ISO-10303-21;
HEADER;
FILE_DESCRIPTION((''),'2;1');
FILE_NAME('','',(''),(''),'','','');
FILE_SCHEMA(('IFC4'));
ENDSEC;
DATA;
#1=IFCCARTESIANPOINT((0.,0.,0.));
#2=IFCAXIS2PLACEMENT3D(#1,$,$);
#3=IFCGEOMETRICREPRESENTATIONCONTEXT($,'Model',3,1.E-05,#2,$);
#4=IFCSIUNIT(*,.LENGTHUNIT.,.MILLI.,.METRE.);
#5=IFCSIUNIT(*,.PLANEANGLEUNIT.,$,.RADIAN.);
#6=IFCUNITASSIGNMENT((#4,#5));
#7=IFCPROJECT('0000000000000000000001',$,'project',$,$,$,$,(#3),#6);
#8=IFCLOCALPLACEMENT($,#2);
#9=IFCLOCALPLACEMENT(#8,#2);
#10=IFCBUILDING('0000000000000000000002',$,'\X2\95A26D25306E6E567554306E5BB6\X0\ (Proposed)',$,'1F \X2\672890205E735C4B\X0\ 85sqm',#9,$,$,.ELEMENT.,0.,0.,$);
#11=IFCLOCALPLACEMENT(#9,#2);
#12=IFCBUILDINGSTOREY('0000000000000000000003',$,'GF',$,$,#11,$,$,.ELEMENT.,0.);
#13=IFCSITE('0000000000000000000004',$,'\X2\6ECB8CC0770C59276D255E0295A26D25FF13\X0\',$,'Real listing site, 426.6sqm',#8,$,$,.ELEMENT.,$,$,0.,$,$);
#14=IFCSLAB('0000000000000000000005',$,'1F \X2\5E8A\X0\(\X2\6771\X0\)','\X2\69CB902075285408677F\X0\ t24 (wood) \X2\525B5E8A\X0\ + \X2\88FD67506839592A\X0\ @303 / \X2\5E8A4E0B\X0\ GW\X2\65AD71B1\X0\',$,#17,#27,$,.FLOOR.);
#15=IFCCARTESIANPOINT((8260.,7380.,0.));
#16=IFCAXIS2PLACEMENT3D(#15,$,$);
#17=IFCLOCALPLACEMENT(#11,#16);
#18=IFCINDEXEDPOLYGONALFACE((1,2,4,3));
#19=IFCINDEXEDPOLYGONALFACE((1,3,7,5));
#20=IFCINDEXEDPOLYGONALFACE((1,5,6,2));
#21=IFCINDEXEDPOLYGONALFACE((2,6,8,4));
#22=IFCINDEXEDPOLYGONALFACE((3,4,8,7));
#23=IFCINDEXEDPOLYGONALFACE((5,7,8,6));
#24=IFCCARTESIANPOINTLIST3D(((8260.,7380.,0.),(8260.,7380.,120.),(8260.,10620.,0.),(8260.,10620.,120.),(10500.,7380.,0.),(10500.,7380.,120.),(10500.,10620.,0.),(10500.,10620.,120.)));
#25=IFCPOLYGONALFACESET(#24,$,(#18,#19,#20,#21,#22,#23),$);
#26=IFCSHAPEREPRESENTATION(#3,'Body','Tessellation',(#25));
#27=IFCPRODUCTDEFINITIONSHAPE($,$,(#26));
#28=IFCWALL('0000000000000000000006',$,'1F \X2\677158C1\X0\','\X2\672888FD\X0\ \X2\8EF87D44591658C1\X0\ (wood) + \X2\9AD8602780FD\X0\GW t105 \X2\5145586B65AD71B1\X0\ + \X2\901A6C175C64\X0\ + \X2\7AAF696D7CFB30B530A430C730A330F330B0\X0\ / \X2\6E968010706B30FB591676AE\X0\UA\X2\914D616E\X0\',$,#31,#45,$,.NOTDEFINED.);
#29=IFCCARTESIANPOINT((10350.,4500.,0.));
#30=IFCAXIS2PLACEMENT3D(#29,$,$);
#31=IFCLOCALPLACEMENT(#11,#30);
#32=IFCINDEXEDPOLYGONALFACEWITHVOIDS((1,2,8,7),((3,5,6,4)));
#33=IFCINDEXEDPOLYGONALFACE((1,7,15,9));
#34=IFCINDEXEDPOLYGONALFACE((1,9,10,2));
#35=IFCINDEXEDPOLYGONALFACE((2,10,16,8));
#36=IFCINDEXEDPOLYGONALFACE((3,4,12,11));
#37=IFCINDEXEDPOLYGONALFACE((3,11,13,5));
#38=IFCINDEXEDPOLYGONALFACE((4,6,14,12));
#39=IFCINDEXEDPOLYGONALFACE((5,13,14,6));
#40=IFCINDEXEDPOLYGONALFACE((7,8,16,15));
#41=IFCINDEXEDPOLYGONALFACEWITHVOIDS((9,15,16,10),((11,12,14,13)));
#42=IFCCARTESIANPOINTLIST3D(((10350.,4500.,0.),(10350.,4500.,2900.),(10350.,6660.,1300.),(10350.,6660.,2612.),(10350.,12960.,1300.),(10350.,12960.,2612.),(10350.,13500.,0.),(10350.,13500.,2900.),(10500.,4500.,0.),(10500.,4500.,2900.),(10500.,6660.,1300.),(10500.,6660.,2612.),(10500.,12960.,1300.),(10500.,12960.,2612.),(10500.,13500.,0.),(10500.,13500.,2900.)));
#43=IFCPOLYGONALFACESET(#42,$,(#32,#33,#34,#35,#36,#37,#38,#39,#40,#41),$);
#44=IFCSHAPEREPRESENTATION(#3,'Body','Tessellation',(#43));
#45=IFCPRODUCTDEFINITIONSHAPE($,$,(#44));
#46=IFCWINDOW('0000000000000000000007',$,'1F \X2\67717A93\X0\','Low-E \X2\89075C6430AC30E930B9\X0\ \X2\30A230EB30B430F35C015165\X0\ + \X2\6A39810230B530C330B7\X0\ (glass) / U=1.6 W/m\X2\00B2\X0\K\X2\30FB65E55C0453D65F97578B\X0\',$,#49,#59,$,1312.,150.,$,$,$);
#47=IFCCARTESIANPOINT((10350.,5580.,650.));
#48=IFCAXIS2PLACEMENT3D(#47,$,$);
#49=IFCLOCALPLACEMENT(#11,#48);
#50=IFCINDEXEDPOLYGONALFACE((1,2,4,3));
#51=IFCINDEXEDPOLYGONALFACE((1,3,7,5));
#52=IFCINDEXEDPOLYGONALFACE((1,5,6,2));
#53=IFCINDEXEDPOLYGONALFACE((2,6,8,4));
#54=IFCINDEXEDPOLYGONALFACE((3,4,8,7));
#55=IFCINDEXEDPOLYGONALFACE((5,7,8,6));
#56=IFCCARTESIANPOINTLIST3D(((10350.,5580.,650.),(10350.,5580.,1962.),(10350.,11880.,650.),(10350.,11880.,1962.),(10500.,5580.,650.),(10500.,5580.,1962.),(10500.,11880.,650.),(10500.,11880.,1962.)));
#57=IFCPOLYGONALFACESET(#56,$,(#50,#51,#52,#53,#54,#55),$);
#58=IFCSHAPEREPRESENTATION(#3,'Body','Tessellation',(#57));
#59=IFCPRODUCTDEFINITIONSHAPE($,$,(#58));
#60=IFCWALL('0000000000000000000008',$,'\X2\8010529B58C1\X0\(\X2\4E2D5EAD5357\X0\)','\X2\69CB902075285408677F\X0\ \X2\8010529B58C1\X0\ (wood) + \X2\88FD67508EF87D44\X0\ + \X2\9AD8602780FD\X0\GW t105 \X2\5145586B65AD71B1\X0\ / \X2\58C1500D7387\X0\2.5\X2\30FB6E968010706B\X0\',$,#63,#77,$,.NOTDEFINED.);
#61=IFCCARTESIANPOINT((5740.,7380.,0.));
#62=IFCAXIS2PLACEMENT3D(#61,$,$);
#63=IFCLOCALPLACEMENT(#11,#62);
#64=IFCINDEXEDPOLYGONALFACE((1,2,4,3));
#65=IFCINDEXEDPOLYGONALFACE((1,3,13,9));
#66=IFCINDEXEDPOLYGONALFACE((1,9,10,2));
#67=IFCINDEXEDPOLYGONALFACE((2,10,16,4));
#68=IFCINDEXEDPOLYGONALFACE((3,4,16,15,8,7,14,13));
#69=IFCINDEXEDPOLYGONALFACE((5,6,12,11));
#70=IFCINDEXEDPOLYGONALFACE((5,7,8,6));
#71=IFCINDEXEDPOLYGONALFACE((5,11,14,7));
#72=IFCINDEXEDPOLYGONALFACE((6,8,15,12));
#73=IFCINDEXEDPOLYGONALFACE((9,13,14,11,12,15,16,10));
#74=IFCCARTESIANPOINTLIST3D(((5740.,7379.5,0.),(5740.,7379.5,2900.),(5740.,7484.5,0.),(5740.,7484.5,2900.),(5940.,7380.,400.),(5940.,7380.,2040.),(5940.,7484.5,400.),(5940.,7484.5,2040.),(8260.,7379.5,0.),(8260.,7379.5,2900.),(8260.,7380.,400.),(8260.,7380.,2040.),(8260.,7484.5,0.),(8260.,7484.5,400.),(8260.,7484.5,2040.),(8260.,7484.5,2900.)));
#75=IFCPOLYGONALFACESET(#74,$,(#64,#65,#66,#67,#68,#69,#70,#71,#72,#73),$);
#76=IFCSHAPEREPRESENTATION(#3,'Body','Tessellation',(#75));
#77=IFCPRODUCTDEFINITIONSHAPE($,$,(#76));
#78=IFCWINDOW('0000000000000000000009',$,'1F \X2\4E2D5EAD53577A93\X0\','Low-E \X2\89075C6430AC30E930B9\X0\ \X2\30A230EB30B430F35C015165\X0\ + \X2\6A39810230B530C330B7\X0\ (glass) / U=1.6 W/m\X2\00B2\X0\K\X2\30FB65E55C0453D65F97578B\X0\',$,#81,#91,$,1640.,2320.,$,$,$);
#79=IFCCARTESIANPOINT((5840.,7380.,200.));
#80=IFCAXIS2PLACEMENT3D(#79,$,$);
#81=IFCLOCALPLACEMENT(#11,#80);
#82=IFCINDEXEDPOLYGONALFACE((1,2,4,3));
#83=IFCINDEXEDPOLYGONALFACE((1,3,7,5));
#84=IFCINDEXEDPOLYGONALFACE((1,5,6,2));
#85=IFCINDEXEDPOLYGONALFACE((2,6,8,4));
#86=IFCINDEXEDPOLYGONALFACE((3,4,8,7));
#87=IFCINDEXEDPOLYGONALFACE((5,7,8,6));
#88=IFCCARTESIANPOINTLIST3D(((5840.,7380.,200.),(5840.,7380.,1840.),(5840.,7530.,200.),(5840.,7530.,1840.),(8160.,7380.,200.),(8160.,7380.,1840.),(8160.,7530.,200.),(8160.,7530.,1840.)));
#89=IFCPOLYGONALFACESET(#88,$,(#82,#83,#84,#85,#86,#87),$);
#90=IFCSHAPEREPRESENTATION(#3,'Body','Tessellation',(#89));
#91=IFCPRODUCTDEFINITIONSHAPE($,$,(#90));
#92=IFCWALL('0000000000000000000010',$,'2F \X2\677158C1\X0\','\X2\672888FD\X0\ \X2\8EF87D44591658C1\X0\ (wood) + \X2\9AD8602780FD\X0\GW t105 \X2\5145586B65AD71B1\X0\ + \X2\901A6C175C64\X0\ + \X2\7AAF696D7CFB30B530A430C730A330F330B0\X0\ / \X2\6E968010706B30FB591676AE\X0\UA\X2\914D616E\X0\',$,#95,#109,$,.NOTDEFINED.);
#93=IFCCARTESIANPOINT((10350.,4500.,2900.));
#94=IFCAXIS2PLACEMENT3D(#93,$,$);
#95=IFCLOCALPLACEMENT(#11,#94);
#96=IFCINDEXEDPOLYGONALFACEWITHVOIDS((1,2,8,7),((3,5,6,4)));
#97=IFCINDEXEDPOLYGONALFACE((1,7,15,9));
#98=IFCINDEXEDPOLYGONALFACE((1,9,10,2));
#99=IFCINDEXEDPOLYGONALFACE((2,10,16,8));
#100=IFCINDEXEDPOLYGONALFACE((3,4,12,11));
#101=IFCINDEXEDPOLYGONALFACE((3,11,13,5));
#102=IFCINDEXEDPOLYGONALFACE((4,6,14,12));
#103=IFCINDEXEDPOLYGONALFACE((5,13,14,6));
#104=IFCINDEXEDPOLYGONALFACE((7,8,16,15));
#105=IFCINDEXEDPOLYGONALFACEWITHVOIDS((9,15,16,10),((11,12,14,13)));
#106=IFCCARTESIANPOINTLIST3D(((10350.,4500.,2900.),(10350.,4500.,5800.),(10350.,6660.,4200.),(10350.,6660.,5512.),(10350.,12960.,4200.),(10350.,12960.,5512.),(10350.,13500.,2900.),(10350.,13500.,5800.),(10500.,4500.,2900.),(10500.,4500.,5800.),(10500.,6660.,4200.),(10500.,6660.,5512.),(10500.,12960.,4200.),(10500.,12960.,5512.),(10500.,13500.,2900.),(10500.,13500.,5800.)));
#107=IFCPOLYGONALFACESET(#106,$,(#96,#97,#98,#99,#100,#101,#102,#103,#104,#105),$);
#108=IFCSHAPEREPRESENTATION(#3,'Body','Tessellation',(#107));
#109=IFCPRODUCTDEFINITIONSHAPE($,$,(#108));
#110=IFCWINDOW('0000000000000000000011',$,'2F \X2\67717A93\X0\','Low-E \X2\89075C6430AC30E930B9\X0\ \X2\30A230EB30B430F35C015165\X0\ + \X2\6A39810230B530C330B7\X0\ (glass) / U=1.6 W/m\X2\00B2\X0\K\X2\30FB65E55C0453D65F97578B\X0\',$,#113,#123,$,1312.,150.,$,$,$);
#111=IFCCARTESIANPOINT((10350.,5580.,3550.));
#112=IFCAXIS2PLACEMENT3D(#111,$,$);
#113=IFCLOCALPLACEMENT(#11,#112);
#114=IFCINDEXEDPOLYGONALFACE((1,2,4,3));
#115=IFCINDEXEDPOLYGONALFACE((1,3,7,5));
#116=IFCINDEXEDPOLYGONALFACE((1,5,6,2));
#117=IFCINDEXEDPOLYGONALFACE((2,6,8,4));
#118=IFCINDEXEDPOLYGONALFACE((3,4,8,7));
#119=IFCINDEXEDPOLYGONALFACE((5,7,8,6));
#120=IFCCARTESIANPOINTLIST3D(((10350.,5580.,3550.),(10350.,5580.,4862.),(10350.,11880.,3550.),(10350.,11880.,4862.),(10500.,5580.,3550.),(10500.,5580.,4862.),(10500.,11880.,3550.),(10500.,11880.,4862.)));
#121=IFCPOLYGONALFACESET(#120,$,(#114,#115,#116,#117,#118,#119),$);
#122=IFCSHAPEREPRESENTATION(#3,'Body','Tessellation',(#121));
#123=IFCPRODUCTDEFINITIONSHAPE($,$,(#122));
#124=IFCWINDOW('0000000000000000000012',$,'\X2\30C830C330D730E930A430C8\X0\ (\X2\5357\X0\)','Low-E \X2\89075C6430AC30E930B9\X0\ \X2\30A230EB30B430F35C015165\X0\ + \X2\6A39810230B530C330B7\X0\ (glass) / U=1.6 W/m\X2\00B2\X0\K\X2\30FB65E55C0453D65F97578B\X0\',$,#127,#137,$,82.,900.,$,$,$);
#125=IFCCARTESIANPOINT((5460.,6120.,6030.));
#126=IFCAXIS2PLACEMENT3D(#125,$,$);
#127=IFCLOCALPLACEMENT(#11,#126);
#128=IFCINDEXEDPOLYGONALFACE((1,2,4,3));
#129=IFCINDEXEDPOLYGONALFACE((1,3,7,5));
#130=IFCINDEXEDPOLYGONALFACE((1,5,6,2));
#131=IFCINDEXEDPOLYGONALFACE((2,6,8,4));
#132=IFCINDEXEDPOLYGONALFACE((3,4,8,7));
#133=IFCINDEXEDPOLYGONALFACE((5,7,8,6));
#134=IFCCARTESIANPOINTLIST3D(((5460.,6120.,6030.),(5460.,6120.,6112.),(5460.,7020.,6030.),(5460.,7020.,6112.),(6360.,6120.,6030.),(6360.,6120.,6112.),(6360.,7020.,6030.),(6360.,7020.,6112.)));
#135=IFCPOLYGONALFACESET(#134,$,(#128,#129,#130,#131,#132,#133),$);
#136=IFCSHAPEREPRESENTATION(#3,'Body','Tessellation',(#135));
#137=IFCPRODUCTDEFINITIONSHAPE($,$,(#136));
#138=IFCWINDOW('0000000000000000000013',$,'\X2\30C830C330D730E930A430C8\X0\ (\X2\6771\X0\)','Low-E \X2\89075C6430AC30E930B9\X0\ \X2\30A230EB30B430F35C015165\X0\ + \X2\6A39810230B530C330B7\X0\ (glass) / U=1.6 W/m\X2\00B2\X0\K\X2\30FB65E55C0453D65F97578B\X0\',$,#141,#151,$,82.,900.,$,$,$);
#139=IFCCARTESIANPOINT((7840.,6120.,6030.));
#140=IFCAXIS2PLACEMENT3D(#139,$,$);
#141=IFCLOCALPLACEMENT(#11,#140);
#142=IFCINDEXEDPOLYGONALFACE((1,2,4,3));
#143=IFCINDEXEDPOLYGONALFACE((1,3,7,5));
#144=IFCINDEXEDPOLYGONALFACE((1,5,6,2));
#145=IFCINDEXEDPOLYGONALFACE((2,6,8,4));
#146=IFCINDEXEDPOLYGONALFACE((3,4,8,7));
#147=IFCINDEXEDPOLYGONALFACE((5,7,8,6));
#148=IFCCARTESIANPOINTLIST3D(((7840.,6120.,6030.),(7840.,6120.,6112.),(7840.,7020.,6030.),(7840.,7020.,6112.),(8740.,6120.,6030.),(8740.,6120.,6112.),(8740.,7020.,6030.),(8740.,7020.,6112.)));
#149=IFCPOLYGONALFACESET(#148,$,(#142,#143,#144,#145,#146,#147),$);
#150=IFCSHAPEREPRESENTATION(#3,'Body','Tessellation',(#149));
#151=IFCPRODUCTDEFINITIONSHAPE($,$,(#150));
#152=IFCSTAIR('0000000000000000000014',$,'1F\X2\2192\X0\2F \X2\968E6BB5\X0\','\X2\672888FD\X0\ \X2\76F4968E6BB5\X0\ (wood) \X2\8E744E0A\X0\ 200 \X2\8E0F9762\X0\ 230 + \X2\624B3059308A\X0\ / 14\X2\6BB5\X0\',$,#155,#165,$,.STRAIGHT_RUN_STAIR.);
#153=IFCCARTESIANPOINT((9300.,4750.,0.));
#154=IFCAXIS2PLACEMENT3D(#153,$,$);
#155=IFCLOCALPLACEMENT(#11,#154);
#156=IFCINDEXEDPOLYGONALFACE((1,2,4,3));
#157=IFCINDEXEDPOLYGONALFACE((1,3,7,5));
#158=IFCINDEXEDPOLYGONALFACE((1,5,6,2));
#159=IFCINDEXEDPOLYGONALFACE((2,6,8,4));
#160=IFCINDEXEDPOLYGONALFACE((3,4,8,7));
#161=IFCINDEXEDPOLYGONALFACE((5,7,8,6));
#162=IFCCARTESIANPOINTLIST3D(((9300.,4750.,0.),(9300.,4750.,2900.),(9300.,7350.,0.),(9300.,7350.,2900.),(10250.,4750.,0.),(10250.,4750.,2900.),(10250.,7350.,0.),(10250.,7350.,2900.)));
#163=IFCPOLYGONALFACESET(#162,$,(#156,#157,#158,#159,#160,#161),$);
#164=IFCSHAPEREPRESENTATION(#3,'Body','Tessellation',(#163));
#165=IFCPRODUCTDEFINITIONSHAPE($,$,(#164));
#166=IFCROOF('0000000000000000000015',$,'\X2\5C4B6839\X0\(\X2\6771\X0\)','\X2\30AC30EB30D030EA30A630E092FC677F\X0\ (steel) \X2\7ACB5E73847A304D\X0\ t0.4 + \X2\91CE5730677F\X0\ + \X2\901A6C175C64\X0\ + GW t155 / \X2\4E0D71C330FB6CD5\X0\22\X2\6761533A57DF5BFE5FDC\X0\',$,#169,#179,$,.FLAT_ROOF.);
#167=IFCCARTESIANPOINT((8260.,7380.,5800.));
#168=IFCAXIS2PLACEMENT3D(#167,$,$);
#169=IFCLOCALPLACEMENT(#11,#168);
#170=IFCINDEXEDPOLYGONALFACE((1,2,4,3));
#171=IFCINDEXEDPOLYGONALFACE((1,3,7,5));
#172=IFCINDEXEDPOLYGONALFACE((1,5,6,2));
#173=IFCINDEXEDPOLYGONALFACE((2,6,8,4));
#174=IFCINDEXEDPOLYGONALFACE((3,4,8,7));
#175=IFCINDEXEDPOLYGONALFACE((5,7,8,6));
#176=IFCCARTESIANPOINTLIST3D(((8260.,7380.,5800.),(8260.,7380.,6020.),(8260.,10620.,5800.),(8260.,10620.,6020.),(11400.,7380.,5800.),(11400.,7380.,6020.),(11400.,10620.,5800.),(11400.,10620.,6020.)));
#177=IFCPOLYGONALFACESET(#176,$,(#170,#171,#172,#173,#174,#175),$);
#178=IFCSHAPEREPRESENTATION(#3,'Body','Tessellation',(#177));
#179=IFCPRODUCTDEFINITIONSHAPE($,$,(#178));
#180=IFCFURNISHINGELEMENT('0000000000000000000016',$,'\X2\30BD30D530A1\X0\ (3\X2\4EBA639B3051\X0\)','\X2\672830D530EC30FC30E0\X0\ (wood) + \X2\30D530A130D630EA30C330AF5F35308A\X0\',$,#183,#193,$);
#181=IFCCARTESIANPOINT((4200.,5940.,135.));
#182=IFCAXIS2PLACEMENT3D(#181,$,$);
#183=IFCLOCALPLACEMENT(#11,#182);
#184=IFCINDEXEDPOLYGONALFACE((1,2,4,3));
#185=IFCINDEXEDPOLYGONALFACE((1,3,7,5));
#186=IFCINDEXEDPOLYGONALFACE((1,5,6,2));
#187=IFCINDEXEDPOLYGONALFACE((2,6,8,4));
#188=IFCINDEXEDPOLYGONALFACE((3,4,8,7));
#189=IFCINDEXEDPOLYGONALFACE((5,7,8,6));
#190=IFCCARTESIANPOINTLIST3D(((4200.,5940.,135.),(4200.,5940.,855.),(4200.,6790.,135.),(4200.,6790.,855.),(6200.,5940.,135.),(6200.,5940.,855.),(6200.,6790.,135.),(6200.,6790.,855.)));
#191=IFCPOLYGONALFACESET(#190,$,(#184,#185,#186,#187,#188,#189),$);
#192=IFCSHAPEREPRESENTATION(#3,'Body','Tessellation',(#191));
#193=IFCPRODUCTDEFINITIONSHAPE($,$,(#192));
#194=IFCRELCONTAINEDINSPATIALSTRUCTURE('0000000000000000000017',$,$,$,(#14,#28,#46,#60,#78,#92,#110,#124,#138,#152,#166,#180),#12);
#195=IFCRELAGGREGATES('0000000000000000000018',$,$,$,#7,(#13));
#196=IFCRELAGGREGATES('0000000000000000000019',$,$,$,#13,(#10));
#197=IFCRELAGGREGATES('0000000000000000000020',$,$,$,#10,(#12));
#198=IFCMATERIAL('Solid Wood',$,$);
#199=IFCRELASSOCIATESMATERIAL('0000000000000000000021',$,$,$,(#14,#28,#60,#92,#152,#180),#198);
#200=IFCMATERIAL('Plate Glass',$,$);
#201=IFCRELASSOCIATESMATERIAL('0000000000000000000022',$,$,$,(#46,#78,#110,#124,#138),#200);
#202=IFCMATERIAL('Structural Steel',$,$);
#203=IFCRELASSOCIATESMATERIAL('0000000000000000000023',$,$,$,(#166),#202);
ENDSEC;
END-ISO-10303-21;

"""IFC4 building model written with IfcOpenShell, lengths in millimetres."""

from ifc_helpers import new_model, si_unit, frame, frame_2d, origin, place, context, project, spatial, rectangle, extrude, material, element, fill, save


model = new_model("IFC4")

# Units and contexts
model_context = context("Model", 3, precision=1e-05, world=origin())
ifc_project = project(units=[si_unit("LENGTHUNIT", "METRE", prefix="MILLI"), si_unit("PLANEANGLEUNIT", "RADIAN")], contexts=[model_context])

# Site, building, storey
site_placement = place(None, origin())
site = spatial("IfcSite", under=ifc_project, at=site_placement, Name="滋賀県大津市関津３", ObjectType="Real listing site, 426.6sqm", CompositionType="ELEMENT", RefElevation=0.0)
building_placement = place(site_placement, origin())
building = spatial("IfcBuilding", under=site, at=building_placement, Name="関津の湖畔の家 (Proposed)", ObjectType="1F 木造平屋 85sqm", CompositionType="ELEMENT", ElevationOfRefHeight=0.0, ElevationOfTerrain=0.0)
storey_placement = place(building_placement, origin())
storey = spatial("IfcBuildingStorey", under=building, at=storey_placement, Name="GF", CompositionType="ELEMENT", Elevation=0.0)

# Slab
ifc_material_1 = material(Name="Solid Wood")
slab_placement = place(storey_placement, frame((8260.0, 7380.0, 0.0)))
element("IfcSlab", 1, at=slab_placement, inside=storey, material=ifc_material_1, Name="1F 床(東)", Description="構造用合板 t24 (wood) 剛床 + 製材根太 @303 / 床下 GW断熱", PredefinedType="FLOOR", context=model_context, shape_type="SweptSolid", body=[
    extrude(rectangle(XDim=2240.0, YDim=3240.0, at=frame_2d((1120.0, 1620.0))), frame((8260.0, 7380.0, 0.0)), (0.0, 0.0, 1.0), 120.0),
])

# Walls, openings, windows
wall_1_placement = place(storey_placement, frame((10350.0, 4500.0, 0.0)))
wall_1 = element("IfcWall", 2, at=wall_1_placement, inside=storey, material=ifc_material_1, Name="1F 東壁", Description="木製 軸組外壁 (wood) + 高性能GW t105 充填断熱 + 通気層 + 窯業系サイディング / 準耐火・外皮UA配慮", PredefinedType="NOTDEFINED", context=model_context, shape_type="SweptSolid", body=[
    extrude(rectangle(XDim=150.0, YDim=9000.0, at=frame_2d((75.0, 4500.0))), frame((10350.0, 4500.0, 0.0)), (0.0, 0.0, 1.0), 2900.0),
])
opening_1_placement = place(storey_placement, frame((10350.0, 5580.0, 650.0)))
opening_1 = element("IfcOpeningElement", 3, at=opening_1_placement, cuts=wall_1, PredefinedType="NOTDEFINED", context=model_context, shape_type="SweptSolid", body=[
    extrude(rectangle(XDim=150.0, YDim=6300.0, at=frame_2d((75.0, 3150.0))), frame((10350.0, 5580.0, 650.0)), (0.0, 0.0, 1.0), 1312.0),
])
ifc_material_2 = material(Name="Plate Glass")
window_1_placement = place(storey_placement, frame((10350.0, 5580.0, 650.0)))
window_1 = element("IfcWindow", 4, at=window_1_placement, inside=storey, material=ifc_material_2, Name="1F 東窓", Description="Low-E 複層ガラス アルゴン封入 + 樹脂サッシ (glass) / U=1.6 W/m²K・日射取得型", OverallHeight=1312.0, OverallWidth=150.0, context=model_context, shape_type="SweptSolid", body=[
    extrude(rectangle(XDim=150.0, YDim=6300.0, at=frame_2d((75.0, 3150.0))), frame((10350.0, 5580.0, 650.0)), (0.0, 0.0, 1.0), 1312.0),
])
fill(opening_1, window_1)
wall_2_placement = place(storey_placement, frame((5740.0, 7380.0, 0.0)))
wall_2 = element("IfcWall", 5, at=wall_2_placement, inside=storey, material=ifc_material_1, Name="耐力壁(中庭南)", Description="構造用合板 耐力壁 (wood) + 製材軸組 + 高性能GW t105 充填断熱 / 壁倍率2.5・準耐火", PredefinedType="NOTDEFINED", context=model_context, shape_type="SweptSolid", body=[
    extrude(rectangle(XDim=2520.0, YDim=105.0, at=frame_2d((1260.0, 52.0))), frame((5740.0, 7380.0, 0.0)), (0.0, 0.0, 1.0), 2900.0),
])
opening_2_placement = place(storey_placement, frame((5840.0, 7380.0, 200.0)))
opening_2 = element("IfcOpeningElement", 6, at=opening_2_placement, cuts=wall_2, PredefinedType="NOTDEFINED", context=model_context, shape_type="SweptSolid", body=[
    extrude(rectangle(XDim=2320.0, YDim=150.0, at=frame_2d((1160.0, 75.0))), frame((5840.0, 7380.0, 200.0)), (0.0, 0.0, 1.0), 1640.0),
])
window_2_placement = place(storey_placement, frame((5840.0, 7380.0, 200.0)))
window_2 = element("IfcWindow", 7, at=window_2_placement, inside=storey, material=ifc_material_2, Name="1F 中庭南窓", Description="Low-E 複層ガラス アルゴン封入 + 樹脂サッシ (glass) / U=1.6 W/m²K・日射取得型", OverallHeight=1640.0, OverallWidth=2320.0, context=model_context, shape_type="SweptSolid", body=[
    extrude(rectangle(XDim=2320.0, YDim=150.0, at=frame_2d((1160.0, 75.0))), frame((5840.0, 7380.0, 200.0)), (0.0, 0.0, 1.0), 1640.0),
])
fill(opening_2, window_2)

# Wall, opening, window
wall_3_placement = place(storey_placement, frame((10350.0, 4500.0, 2900.0)))
wall_3 = element("IfcWall", 8, at=wall_3_placement, inside=storey, material=ifc_material_1, Name="2F 東壁", Description="木製 軸組外壁 (wood) + 高性能GW t105 充填断熱 + 通気層 + 窯業系サイディング / 準耐火・外皮UA配慮", PredefinedType="NOTDEFINED", context=model_context, shape_type="SweptSolid", body=[
    extrude(rectangle(XDim=150.0, YDim=9000.0, at=frame_2d((75.0, 4500.0))), frame((10350.0, 4500.0, 2900.0)), (0.0, 0.0, 1.0), 2900.0),
])
opening_3_placement = place(storey_placement, frame((10350.0, 5580.0, 3550.0)))
opening_3 = element("IfcOpeningElement", 9, at=opening_3_placement, cuts=wall_3, PredefinedType="NOTDEFINED", context=model_context, shape_type="SweptSolid", body=[
    extrude(rectangle(XDim=150.0, YDim=6300.0, at=frame_2d((75.0, 3150.0))), frame((10350.0, 5580.0, 3550.0)), (0.0, 0.0, 1.0), 1312.0),
])
window_3_placement = place(storey_placement, frame((10350.0, 5580.0, 3550.0)))
window_3 = element("IfcWindow", 10, at=window_3_placement, inside=storey, material=ifc_material_2, Name="2F 東窓", Description="Low-E 複層ガラス アルゴン封入 + 樹脂サッシ (glass) / U=1.6 W/m²K・日射取得型", OverallHeight=1312.0, OverallWidth=150.0, context=model_context, shape_type="SweptSolid", body=[
    extrude(rectangle(XDim=150.0, YDim=6300.0, at=frame_2d((75.0, 3150.0))), frame((10350.0, 5580.0, 3550.0)), (0.0, 0.0, 1.0), 1312.0),
])
fill(opening_3, window_3)

# Windows
window_4_placement = place(storey_placement, frame((5460.0, 6120.0, 6030.0)))
element("IfcWindow", 11, at=window_4_placement, inside=storey, material=ifc_material_2, Name="トップライト (南)", Description="Low-E 複層ガラス アルゴン封入 + 樹脂サッシ (glass) / U=1.6 W/m²K・日射取得型", OverallHeight=82.0, OverallWidth=900.0, context=model_context, shape_type="SweptSolid", body=[
    extrude(rectangle(XDim=900.0, YDim=900.0, at=frame_2d((450.0, 450.0))), frame((5460.0, 6120.0, 6030.0)), (0.0, 0.0, 1.0), 82.0),
])
window_5_placement = place(storey_placement, frame((7840.0, 6120.0, 6030.0)))
element("IfcWindow", 12, at=window_5_placement, inside=storey, material=ifc_material_2, Name="トップライト (東)", Description="Low-E 複層ガラス アルゴン封入 + 樹脂サッシ (glass) / U=1.6 W/m²K・日射取得型", OverallHeight=82.0, OverallWidth=900.0, context=model_context, shape_type="SweptSolid", body=[
    extrude(rectangle(XDim=900.0, YDim=900.0, at=frame_2d((450.0, 450.0))), frame((7840.0, 6120.0, 6030.0)), (0.0, 0.0, 1.0), 82.0),
])

# Stair
stair_placement = place(storey_placement, frame((9300.0, 4750.0, 0.0)))
element("IfcStair", 13, at=stair_placement, inside=storey, material=ifc_material_1, Name="1F→2F 階段", Description="木製 直階段 (wood) 蹴上 200 踏面 230 + 手すり / 14段", PredefinedType="STRAIGHT_RUN_STAIR", context=model_context, shape_type="SweptSolid", body=[
    extrude(rectangle(XDim=950.0, YDim=2600.0, at=frame_2d((475.0, 1300.0))), frame((9300.0, 4750.0, 0.0)), (0.0, 0.0, 1.0), 2900.0),
])

# Roof
ifc_material_3 = material(Name="Structural Steel")
roof_placement = place(storey_placement, frame((8260.0, 7380.0, 5800.0)))
element("IfcRoof", 14, at=roof_placement, inside=storey, material=ifc_material_3, Name="屋根(東)", Description="ガルバリウム鋼板 (steel) 立平葺き t0.4 + 野地板 + 通気層 + GW t155 / 不燃・法22条区域対応", PredefinedType="FLAT_ROOF", context=model_context, shape_type="SweptSolid", body=[
    extrude(rectangle(XDim=3140.0, YDim=3240.0, at=frame_2d((1570.0, 1620.0))), frame((8260.0, 7380.0, 5800.0)), (0.0, 0.0, 1.0), 220.0),
])

# Furnishing element
furnishing_1_placement = place(storey_placement, frame((4200.0, 5940.0, 135.0)))
element("IfcFurnishingElement", 15, at=furnishing_1_placement, inside=storey, material=ifc_material_1, Name="ソファ (3人掛け)", Description="木フレーム (wood) + ファブリック張り", context=model_context, shape_type="SweptSolid", body=[
    extrude(rectangle(XDim=2000.0, YDim=850.0, at=frame_2d((1000.0, 425.0))), frame((4200.0, 5940.0, 135.0)), (0.0, 0.0, 1.0), 720.0),
])

save(model, "model.ifc")
